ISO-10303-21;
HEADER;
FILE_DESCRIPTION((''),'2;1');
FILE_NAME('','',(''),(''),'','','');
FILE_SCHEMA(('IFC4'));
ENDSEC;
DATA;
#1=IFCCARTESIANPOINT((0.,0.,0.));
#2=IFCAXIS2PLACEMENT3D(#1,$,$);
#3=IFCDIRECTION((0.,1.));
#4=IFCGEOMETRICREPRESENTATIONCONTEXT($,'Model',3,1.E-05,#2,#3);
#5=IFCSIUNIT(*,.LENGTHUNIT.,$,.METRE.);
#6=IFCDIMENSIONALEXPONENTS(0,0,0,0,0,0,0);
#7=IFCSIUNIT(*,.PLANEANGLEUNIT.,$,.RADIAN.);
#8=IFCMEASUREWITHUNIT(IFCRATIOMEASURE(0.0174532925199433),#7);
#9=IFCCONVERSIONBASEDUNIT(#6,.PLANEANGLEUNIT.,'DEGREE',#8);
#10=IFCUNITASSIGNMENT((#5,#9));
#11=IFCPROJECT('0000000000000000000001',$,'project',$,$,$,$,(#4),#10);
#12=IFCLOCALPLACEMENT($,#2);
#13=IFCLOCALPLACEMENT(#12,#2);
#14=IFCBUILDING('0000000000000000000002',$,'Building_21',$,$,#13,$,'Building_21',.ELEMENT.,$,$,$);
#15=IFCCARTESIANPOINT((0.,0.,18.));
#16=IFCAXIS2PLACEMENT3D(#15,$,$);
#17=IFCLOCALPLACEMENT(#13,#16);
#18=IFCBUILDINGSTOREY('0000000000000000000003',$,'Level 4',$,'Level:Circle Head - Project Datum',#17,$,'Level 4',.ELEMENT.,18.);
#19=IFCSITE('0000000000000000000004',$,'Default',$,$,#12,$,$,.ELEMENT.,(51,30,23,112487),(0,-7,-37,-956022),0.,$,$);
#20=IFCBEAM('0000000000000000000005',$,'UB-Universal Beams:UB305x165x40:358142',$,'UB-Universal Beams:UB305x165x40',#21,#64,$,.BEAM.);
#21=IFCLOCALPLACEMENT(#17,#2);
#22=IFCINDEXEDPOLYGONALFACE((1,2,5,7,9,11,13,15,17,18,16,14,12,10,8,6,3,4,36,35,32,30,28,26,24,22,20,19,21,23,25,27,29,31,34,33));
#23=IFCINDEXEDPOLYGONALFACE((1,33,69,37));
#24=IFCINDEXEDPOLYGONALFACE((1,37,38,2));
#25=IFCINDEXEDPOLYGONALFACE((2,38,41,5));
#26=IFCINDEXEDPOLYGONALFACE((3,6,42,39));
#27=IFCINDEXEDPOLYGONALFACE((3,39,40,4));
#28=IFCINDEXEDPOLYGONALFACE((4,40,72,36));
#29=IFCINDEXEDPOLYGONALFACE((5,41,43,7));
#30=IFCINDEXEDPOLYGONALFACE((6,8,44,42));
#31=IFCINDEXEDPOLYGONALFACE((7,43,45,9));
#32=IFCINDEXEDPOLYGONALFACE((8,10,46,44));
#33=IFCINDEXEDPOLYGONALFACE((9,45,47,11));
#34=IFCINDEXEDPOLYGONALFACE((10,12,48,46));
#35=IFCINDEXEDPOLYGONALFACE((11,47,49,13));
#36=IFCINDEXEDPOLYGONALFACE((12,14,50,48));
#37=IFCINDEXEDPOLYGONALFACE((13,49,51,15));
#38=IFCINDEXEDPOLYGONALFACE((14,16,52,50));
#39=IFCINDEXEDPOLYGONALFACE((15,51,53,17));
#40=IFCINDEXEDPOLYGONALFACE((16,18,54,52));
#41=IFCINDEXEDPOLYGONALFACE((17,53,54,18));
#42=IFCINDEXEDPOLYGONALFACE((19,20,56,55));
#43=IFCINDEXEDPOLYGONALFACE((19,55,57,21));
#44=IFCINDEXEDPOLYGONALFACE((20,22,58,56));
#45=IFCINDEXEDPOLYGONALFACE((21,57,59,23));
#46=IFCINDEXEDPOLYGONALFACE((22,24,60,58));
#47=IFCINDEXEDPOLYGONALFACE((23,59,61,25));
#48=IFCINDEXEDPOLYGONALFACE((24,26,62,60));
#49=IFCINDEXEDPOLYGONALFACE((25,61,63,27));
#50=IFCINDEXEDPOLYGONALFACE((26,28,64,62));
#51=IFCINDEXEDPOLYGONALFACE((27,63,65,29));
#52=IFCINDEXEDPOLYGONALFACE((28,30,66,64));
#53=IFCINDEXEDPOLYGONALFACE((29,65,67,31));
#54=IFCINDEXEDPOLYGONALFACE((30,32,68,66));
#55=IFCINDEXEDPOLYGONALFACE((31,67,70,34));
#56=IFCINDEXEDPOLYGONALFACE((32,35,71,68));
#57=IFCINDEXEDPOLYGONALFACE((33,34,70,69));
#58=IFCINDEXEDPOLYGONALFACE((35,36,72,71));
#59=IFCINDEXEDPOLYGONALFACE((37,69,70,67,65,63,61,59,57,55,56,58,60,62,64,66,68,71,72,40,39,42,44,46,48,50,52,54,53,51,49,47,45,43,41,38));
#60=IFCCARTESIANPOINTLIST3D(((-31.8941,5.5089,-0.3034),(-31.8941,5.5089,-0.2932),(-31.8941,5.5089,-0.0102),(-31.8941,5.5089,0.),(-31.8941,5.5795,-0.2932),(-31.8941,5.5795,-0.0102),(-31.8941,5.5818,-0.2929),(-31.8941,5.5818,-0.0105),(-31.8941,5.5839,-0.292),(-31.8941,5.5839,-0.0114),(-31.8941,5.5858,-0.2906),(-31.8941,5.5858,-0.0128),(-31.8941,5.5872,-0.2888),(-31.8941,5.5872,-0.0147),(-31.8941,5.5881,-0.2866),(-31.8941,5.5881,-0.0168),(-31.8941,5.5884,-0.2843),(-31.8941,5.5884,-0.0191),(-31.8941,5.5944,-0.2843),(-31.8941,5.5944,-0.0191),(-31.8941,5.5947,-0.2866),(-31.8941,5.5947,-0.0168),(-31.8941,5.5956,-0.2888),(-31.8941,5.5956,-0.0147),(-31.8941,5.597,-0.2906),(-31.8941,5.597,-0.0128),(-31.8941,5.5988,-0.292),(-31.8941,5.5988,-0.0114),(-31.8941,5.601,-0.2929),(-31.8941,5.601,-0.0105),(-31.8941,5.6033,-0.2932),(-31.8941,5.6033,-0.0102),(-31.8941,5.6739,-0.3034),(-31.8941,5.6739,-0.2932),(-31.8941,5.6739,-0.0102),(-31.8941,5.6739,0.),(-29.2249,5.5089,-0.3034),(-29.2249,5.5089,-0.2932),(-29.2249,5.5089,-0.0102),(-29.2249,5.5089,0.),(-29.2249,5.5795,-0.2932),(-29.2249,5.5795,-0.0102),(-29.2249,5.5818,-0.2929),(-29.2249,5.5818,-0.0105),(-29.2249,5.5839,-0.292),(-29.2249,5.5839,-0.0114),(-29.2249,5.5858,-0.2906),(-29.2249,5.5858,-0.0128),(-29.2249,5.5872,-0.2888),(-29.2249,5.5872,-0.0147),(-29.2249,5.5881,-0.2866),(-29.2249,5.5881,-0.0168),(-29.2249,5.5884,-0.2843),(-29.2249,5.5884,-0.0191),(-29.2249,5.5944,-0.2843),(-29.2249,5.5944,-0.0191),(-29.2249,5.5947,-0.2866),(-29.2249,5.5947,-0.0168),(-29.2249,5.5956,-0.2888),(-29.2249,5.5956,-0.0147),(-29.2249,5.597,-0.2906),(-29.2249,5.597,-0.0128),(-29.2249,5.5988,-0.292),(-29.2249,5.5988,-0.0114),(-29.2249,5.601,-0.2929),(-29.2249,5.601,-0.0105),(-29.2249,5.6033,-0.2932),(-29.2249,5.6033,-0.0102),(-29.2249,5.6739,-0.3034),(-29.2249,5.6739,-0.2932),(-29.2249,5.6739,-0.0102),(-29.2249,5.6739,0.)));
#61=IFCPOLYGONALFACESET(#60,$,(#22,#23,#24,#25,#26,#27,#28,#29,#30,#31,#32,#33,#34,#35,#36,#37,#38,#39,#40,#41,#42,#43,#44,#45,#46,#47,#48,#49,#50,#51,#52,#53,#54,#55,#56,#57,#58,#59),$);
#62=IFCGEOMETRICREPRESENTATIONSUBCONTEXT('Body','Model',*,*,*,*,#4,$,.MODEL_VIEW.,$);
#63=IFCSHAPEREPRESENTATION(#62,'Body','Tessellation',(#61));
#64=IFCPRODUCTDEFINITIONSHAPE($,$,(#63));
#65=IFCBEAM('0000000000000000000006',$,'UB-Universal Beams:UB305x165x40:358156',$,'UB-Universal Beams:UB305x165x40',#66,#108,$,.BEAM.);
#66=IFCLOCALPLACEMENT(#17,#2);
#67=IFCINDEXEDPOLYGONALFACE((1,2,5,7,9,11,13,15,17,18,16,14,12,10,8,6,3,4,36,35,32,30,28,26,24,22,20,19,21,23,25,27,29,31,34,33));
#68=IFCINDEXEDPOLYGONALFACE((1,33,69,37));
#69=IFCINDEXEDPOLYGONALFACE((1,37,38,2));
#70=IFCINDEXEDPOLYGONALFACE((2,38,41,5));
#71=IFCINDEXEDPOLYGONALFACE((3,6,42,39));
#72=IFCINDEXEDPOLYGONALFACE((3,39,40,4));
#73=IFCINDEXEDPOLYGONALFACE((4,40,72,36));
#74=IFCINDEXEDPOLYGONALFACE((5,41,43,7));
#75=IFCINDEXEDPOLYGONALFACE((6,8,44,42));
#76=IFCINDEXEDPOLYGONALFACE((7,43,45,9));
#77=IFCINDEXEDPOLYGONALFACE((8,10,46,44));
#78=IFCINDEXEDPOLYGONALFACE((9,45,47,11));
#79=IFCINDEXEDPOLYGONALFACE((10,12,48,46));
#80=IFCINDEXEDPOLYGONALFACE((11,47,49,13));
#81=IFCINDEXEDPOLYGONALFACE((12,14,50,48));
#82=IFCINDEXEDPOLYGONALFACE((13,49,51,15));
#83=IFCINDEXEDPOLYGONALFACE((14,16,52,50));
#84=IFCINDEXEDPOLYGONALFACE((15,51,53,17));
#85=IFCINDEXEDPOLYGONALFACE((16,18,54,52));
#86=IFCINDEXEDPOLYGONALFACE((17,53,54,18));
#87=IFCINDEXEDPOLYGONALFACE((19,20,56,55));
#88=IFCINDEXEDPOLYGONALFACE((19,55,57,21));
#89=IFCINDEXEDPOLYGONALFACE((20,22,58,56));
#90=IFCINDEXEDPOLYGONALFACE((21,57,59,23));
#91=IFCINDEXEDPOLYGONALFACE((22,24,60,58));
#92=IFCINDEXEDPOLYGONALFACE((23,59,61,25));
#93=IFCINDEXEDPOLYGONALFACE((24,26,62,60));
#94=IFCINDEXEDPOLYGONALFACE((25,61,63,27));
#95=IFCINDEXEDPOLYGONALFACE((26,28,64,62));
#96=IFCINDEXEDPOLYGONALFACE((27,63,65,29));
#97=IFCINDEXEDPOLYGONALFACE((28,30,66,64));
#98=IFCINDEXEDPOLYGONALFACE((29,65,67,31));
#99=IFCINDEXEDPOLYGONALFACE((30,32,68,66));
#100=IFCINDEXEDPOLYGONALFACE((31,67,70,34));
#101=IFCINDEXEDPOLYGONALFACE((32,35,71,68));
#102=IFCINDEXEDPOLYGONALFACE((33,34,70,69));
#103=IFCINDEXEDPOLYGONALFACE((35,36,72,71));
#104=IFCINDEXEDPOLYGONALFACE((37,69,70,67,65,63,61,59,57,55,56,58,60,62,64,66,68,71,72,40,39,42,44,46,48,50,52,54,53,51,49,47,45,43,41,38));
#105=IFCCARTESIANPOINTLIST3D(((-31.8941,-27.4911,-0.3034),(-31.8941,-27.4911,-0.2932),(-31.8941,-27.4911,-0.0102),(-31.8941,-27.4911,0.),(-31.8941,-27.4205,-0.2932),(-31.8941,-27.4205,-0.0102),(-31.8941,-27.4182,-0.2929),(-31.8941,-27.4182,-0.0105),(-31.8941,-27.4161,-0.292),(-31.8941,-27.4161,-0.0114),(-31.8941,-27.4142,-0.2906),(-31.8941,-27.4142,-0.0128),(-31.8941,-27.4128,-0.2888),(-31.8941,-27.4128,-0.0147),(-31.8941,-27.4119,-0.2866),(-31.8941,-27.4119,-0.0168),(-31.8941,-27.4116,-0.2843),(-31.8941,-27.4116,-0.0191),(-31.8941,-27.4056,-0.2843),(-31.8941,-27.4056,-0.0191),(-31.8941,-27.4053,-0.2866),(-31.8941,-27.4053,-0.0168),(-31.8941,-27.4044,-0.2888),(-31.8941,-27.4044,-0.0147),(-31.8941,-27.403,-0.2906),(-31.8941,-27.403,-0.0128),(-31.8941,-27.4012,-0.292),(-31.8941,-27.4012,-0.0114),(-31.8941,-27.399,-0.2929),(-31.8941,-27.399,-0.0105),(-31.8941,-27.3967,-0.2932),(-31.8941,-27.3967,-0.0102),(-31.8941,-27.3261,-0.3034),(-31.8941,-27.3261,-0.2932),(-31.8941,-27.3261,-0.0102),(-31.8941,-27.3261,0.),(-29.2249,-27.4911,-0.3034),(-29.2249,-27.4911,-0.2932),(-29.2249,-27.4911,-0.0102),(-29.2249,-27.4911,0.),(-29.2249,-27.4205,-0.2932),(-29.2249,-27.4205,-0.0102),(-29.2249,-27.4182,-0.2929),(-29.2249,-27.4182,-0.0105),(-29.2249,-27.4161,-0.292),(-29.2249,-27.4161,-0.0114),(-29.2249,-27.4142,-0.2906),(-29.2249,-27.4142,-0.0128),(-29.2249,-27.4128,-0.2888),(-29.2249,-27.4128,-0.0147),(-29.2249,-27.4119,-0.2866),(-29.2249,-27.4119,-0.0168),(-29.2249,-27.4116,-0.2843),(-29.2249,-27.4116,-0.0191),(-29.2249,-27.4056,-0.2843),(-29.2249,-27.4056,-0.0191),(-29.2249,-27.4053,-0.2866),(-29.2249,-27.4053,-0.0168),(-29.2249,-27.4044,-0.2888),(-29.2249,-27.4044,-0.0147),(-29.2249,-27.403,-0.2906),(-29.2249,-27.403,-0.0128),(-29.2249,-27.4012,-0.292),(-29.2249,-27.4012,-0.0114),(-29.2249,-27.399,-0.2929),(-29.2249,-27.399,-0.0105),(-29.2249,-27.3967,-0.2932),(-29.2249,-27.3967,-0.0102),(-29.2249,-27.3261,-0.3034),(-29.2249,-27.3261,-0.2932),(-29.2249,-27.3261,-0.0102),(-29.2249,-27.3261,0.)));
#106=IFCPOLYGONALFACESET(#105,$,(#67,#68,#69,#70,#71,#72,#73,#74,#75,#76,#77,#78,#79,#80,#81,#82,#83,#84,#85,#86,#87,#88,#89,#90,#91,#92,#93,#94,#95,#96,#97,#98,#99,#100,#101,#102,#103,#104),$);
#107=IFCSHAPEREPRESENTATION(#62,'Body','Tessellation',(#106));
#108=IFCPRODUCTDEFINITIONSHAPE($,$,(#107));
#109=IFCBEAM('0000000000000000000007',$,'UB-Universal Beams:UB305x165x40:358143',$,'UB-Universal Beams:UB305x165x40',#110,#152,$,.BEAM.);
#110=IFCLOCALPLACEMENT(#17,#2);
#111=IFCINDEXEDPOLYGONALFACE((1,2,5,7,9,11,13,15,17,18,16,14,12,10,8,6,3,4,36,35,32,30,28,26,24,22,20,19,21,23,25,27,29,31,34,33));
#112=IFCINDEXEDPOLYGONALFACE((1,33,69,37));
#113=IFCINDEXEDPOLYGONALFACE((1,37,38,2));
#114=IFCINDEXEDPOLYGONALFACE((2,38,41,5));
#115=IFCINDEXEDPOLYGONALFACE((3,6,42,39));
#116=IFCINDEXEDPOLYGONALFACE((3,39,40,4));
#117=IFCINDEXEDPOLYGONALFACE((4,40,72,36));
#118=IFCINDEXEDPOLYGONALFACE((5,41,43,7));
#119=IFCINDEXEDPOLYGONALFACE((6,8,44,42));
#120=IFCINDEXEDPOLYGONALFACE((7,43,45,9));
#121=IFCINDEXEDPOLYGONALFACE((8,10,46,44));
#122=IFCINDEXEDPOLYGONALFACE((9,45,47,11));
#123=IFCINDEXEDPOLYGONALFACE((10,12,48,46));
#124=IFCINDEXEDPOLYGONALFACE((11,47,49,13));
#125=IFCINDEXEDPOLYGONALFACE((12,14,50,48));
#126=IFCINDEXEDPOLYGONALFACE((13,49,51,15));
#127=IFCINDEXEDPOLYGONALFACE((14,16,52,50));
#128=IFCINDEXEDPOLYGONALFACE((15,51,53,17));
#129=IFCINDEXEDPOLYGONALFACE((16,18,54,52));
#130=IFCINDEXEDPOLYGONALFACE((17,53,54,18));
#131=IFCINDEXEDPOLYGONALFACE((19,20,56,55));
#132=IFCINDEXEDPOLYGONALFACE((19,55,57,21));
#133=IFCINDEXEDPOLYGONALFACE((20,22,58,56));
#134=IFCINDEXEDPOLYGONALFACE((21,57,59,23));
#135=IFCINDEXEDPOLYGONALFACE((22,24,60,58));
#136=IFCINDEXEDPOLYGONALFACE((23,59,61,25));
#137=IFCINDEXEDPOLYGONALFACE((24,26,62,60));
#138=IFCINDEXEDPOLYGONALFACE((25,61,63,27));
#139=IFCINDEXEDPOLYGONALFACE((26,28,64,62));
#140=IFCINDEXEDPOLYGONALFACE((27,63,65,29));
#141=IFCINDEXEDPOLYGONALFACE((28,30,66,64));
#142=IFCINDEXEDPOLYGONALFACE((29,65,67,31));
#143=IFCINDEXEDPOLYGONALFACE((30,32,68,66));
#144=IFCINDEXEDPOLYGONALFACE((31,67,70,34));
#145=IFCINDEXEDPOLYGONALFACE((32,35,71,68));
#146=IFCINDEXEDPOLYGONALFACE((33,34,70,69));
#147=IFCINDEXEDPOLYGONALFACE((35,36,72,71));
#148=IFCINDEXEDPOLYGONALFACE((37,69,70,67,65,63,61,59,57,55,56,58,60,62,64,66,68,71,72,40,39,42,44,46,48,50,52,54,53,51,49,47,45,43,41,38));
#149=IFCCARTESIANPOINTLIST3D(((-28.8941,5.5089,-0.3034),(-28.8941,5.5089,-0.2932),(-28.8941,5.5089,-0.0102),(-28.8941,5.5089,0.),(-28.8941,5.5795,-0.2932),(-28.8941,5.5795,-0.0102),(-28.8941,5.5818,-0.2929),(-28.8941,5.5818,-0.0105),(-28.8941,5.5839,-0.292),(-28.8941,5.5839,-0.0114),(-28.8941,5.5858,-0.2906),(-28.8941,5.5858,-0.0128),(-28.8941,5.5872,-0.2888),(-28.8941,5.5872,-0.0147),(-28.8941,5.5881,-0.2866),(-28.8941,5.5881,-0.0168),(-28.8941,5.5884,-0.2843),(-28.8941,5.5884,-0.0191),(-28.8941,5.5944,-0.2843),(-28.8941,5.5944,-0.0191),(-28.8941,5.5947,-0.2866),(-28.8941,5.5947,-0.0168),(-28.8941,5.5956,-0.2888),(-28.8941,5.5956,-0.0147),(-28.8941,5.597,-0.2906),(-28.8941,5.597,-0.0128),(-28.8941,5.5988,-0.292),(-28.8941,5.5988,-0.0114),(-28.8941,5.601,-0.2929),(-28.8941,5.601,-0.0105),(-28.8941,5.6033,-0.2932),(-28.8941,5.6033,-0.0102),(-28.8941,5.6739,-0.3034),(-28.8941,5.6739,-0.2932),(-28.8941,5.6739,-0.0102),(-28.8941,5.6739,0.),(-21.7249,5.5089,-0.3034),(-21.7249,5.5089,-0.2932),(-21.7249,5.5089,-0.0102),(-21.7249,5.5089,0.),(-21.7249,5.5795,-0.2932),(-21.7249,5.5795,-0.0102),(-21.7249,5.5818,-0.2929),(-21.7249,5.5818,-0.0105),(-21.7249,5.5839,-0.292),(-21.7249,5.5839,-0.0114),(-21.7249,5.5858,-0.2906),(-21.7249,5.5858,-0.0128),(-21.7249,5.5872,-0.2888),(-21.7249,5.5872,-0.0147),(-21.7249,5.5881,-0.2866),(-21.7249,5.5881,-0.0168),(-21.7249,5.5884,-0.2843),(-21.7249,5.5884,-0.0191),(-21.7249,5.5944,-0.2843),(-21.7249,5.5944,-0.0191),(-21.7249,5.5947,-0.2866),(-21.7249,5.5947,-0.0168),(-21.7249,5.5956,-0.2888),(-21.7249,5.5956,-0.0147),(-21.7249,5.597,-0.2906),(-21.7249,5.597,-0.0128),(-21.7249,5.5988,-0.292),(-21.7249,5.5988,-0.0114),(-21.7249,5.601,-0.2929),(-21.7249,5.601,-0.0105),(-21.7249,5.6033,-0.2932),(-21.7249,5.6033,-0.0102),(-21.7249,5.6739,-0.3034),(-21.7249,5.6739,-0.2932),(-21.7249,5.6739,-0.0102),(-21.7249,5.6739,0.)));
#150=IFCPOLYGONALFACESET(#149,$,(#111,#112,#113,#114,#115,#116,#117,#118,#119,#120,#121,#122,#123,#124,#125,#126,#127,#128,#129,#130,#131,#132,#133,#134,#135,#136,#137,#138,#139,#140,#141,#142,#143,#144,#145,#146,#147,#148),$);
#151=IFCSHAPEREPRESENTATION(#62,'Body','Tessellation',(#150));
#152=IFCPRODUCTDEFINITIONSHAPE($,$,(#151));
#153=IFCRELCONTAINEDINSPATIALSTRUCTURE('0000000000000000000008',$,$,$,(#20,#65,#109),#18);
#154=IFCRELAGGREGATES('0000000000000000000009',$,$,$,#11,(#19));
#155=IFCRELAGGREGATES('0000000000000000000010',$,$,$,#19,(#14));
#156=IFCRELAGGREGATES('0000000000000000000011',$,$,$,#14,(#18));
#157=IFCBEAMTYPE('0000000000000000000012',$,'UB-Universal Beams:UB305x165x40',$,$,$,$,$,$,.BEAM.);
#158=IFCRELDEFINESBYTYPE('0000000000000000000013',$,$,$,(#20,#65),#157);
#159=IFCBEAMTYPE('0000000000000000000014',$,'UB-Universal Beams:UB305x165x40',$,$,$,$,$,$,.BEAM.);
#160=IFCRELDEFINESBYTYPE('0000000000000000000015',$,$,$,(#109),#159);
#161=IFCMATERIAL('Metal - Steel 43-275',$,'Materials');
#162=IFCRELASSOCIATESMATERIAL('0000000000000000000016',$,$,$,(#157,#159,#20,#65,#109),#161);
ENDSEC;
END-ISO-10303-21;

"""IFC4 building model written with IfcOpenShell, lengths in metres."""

from ifc_helpers import new_model, entity, si_unit, converted_unit, direction, frame, frame_2d, origin, place, context, subcontext, project, spatial, polyline, circle_curve, parameter, trimmed, segment, composite_curve, i_section, outline, extrude, source, transform, mapped, material, material_profile, profile_set, profile_usage, type_object, type_shapes, element, save


model = new_model("IFC4")

# Units and contexts
model_context = context("Model", 3, precision=1e-05, world=origin(), true_north=direction((0.0, 1.0)))
body_context = subcontext(model_context, "Body", "Model", "MODEL_VIEW")
ifc_project = project(units=[si_unit("LENGTHUNIT", "METRE"), converted_unit("PLANEANGLEUNIT", "DEGREE", entity("IfcRatioMeasure", 0.0174532925199433), si_unit("PLANEANGLEUNIT", "RADIAN"), dimensions=[0, 0, 0, 0, 0, 0, 0])], contexts=[model_context])

# Site, building, storey
site_placement = place(None, origin())
site = spatial("IfcSite", under=ifc_project, at=site_placement, Name="Default", CompositionType="ELEMENT", RefLatitude=(51, 30, 23, 112487), RefLongitude=(0, -7, -37, -956022), RefElevation=0.0)
building_placement = place(site_placement, origin())
building = spatial("IfcBuilding", under=site, at=building_placement, Name="Building_21", LongName="Building_21", CompositionType="ELEMENT")
storey_placement = place(building_placement, frame((0.0, 0.0, 18.0)))
storey = spatial("IfcBuildingStorey", under=building, at=storey_placement, Name="Level 4", ObjectType="Level:Circle Head - Project Datum", LongName="Level 4", CompositionType="ELEMENT", Elevation=18.0)

# Beams
ifc_material_1 = material(Name="Metal - Steel 43-275", Category="Materials")
ifc_material_profile_1 = material_profile(ifc_material_1, outline(composite_curve([segment(polyline([(0.0119, -0.1415, 0.0), (0.0825, -0.1415, 0.0)]), True, "CONTINUOUS"), segment(polyline([(0.0825, -0.1415, 0.0), (0.0825, -0.1517, 0.0)]), True, "CONTINUOUS"), segment(polyline([(0.0825, -0.1517, 0.0), (-0.0825, -0.1517, 0.0)]), True, "CONTINUOUS"), segment(polyline([(-0.0825, -0.1517, 0.0), (-0.0825, -0.1415, 0.0)]), True, "CONTINUOUS"), segment(polyline([(-0.0825, -0.1415, 0.0), (-0.0119, -0.1415, 0.0)]), True, "CONTINUOUS"), segment(trimmed(circle_curve(frame((-0.0119, -0.1326, 0.0), z_axis=(0.0, 0.0, 1.0), x_axis=(-1.0, 0.0, 0.0)), 0.0089), [parameter(90.0)], [parameter(180.0)], True, "PARAMETER"), True, "CONTINUOUS"), segment(polyline([(-0.003, -0.1326, 0.0), (-0.003, 0.1326, 0.0)]), True, "CONTINUOUS"), segment(trimmed(circle_curve(frame((-0.0119, 0.1326, 0.0), z_axis=(0.0, 0.0, 1.0), x_axis=(-1.0, 0.0, 0.0)), 0.0089), [parameter(180.0)], [parameter(270.0)], True, "PARAMETER"), True, "CONTINUOUS"), segment(polyline([(-0.0119, 0.1415, 0.0), (-0.0825, 0.1415, 0.0)]), True, "CONTINUOUS"), segment(polyline([(-0.0825, 0.1415, 0.0), (-0.0825, 0.1517, 0.0)]), True, "CONTINUOUS"), segment(polyline([(-0.0825, 0.1517, 0.0), (0.0825, 0.1517, 0.0)]), True, "CONTINUOUS"), segment(polyline([(0.0825, 0.1517, 0.0), (0.0825, 0.1415, 0.0)]), True, "CONTINUOUS"), segment(polyline([(0.0825, 0.1415, 0.0), (0.0119, 0.1415, 0.0)]), True, "CONTINUOUS"), segment(trimmed(circle_curve(frame((0.0119, 0.1326, 0.0), z_axis=(0.0, 0.0, 1.0), x_axis=(-1.0, 0.0, 0.0)), 0.0089), [parameter(270.0)], [parameter(0.0)], True, "PARAMETER"), True, "CONTINUOUS"), segment(polyline([(0.003, 0.1326, 0.0), (0.003, -0.1326, 0.0)]), True, "CONTINUOUS"), segment(trimmed(circle_curve(frame((0.0119, -0.1326, 0.0), z_axis=(0.0, 0.0, 1.0), x_axis=(-1.0, 0.0, 0.0)), 0.0089), [parameter(0.0)], [parameter(90.0)], True, "PARAMETER"), True, "CONTINUOUS")], self_intersect=False), kind="CURVE"), Name="UB305x165x40")
ifc_material_profile_2 = material_profile(ifc_material_1, outline(composite_curve([segment(polyline([(-1.3346, 0.0825, -0.1415), (-1.3346, 0.0825, -0.1517)]), True, "CONTINUOUS"), segment(polyline([(-1.3346, 0.0825, -0.1517), (-1.3346, -0.0825, -0.1517)]), True, "CONTINUOUS"), segment(polyline([(-1.3346, -0.0825, -0.1517), (-1.3346, -0.0825, -0.1415)]), True, "CONTINUOUS"), segment(polyline([(-1.3346, -0.0825, -0.1415), (-1.3346, -0.003, -0.1415)]), True, "CONTINUOUS"), segment(polyline([(-1.3346, -0.003, -0.1415), (-1.3346, -0.003, 0.1415)]), True, "CONTINUOUS"), segment(polyline([(-1.3346, -0.003, 0.1415), (-1.3346, -0.0825, 0.1415)]), True, "CONTINUOUS"), segment(polyline([(-1.3346, -0.0825, 0.1415), (-1.3346, -0.0825, 0.1517)]), True, "CONTINUOUS"), segment(polyline([(-1.3346, -0.0825, 0.1517), (-1.3346, 0.0825, 0.1517)]), True, "CONTINUOUS"), segment(polyline([(-1.3346, 0.0825, 0.1517), (-1.3346, 0.0825, 0.1415)]), True, "CONTINUOUS"), segment(polyline([(-1.3346, 0.0825, 0.1415), (-1.3346, 0.003, 0.1415)]), True, "CONTINUOUS"), segment(polyline([(-1.3346, 0.003, 0.1415), (-1.3346, 0.003, -0.1415)]), True, "CONTINUOUS"), segment(polyline([(-1.3346, 0.003, -0.1415), (-1.3346, 0.0825, -0.1415)]), True, "CONTINUOUS")], self_intersect=False), kind="CURVE"), Name="UB305x165x40")
ifc_profile_set = profile_set([ifc_material_profile_1, ifc_material_profile_2], Name="UB305x165x40")
ifc_profile_usage_1 = profile_usage(ifc_profile_set, cardinal=8)
beam_type_1 = type_object("IfcBeamType", Name="UB-Universal Beams:UB305x165x40", PredefinedType="BEAM", material=ifc_profile_set)
shared_shape_1 = source(origin(), body_context, "Body", "SweptSolid", [
    extrude(i_section(OverallWidth=0.165, OverallDepth=0.3034, WebThickness=0.006, FlangeThickness=0.0102, FilletRadius=0.0089, at=frame_2d((0.0, 0.0), x_axis=(0.0, 1.0))), frame((-1.3346, 0.0, 0.0), z_axis=(1.0, 0.0, 0.0), x_axis=(0.0, 0.0, -1.0)), (0.0, 0.0, 1.0), 2.6692),
])
type_shapes(beam_type_1, [shared_shape_1])
beam_1_placement = place(storey_placement, frame((-30.5595, 5.5914, -0.1517)))
element("IfcBeam", 1, at=beam_1_placement, inside=storey, type_object=beam_type_1, material=ifc_profile_usage_1, Name="UB-Universal Beams:UB305x165x40:358142", ObjectType="UB-Universal Beams:UB305x165x40", PredefinedType="BEAM", context=body_context, shape_type="MappedRepresentation", body=[
    mapped(shared_shape_1, transform((0.0, 0.0, 0.0), scale=1.0)),
])
ifc_profile_usage_2 = profile_usage(ifc_profile_set, cardinal=8)
beam_2_placement = place(storey_placement, frame((-30.5595, -27.4086, -0.1517)))
element("IfcBeam", 2, at=beam_2_placement, inside=storey, type_object=beam_type_1, material=ifc_profile_usage_2, Name="UB-Universal Beams:UB305x165x40:358156", ObjectType="UB-Universal Beams:UB305x165x40", PredefinedType="BEAM", context=body_context, shape_type="MappedRepresentation", body=[
    mapped(shared_shape_1, transform((0.0, 0.0, 0.0), scale=1.0)),
])
ifc_profile_usage_3 = profile_usage(ifc_profile_set, cardinal=8)
beam_type_2 = type_object("IfcBeamType", Name="UB-Universal Beams:UB305x165x40", PredefinedType="BEAM", material=ifc_profile_set)
shared_shape_2 = source(origin(), body_context, "Body", "SweptSolid", [
    extrude(i_section(OverallWidth=0.165, OverallDepth=0.3034, WebThickness=0.006, FlangeThickness=0.0102, FilletRadius=0.0089, at=frame_2d((0.0, 0.0), x_axis=(0.0, 1.0))), frame((-3.5846, 0.0, 0.0), z_axis=(1.0, 0.0, 0.0), x_axis=(0.0, 0.0, -1.0)), (0.0, 0.0, 1.0), 7.1692),
])
type_shapes(beam_type_2, [shared_shape_2])
beam_3_placement = place(storey_placement, frame((-25.3095, 5.5914, -0.1517), z_axis=(0.0, 0.0, 1.0), x_axis=(-1.0, 0.0, 0.0)))
element("IfcBeam", 3, at=beam_3_placement, inside=storey, type_object=beam_type_2, material=ifc_profile_usage_3, Name="UB-Universal Beams:UB305x165x40:358143", ObjectType="UB-Universal Beams:UB305x165x40", PredefinedType="BEAM", context=body_context, shape_type="MappedRepresentation", body=[
    mapped(shared_shape_2, transform((0.0, 0.0, 0.0), scale=1.0)),
])

save(model, "model.ifc")
